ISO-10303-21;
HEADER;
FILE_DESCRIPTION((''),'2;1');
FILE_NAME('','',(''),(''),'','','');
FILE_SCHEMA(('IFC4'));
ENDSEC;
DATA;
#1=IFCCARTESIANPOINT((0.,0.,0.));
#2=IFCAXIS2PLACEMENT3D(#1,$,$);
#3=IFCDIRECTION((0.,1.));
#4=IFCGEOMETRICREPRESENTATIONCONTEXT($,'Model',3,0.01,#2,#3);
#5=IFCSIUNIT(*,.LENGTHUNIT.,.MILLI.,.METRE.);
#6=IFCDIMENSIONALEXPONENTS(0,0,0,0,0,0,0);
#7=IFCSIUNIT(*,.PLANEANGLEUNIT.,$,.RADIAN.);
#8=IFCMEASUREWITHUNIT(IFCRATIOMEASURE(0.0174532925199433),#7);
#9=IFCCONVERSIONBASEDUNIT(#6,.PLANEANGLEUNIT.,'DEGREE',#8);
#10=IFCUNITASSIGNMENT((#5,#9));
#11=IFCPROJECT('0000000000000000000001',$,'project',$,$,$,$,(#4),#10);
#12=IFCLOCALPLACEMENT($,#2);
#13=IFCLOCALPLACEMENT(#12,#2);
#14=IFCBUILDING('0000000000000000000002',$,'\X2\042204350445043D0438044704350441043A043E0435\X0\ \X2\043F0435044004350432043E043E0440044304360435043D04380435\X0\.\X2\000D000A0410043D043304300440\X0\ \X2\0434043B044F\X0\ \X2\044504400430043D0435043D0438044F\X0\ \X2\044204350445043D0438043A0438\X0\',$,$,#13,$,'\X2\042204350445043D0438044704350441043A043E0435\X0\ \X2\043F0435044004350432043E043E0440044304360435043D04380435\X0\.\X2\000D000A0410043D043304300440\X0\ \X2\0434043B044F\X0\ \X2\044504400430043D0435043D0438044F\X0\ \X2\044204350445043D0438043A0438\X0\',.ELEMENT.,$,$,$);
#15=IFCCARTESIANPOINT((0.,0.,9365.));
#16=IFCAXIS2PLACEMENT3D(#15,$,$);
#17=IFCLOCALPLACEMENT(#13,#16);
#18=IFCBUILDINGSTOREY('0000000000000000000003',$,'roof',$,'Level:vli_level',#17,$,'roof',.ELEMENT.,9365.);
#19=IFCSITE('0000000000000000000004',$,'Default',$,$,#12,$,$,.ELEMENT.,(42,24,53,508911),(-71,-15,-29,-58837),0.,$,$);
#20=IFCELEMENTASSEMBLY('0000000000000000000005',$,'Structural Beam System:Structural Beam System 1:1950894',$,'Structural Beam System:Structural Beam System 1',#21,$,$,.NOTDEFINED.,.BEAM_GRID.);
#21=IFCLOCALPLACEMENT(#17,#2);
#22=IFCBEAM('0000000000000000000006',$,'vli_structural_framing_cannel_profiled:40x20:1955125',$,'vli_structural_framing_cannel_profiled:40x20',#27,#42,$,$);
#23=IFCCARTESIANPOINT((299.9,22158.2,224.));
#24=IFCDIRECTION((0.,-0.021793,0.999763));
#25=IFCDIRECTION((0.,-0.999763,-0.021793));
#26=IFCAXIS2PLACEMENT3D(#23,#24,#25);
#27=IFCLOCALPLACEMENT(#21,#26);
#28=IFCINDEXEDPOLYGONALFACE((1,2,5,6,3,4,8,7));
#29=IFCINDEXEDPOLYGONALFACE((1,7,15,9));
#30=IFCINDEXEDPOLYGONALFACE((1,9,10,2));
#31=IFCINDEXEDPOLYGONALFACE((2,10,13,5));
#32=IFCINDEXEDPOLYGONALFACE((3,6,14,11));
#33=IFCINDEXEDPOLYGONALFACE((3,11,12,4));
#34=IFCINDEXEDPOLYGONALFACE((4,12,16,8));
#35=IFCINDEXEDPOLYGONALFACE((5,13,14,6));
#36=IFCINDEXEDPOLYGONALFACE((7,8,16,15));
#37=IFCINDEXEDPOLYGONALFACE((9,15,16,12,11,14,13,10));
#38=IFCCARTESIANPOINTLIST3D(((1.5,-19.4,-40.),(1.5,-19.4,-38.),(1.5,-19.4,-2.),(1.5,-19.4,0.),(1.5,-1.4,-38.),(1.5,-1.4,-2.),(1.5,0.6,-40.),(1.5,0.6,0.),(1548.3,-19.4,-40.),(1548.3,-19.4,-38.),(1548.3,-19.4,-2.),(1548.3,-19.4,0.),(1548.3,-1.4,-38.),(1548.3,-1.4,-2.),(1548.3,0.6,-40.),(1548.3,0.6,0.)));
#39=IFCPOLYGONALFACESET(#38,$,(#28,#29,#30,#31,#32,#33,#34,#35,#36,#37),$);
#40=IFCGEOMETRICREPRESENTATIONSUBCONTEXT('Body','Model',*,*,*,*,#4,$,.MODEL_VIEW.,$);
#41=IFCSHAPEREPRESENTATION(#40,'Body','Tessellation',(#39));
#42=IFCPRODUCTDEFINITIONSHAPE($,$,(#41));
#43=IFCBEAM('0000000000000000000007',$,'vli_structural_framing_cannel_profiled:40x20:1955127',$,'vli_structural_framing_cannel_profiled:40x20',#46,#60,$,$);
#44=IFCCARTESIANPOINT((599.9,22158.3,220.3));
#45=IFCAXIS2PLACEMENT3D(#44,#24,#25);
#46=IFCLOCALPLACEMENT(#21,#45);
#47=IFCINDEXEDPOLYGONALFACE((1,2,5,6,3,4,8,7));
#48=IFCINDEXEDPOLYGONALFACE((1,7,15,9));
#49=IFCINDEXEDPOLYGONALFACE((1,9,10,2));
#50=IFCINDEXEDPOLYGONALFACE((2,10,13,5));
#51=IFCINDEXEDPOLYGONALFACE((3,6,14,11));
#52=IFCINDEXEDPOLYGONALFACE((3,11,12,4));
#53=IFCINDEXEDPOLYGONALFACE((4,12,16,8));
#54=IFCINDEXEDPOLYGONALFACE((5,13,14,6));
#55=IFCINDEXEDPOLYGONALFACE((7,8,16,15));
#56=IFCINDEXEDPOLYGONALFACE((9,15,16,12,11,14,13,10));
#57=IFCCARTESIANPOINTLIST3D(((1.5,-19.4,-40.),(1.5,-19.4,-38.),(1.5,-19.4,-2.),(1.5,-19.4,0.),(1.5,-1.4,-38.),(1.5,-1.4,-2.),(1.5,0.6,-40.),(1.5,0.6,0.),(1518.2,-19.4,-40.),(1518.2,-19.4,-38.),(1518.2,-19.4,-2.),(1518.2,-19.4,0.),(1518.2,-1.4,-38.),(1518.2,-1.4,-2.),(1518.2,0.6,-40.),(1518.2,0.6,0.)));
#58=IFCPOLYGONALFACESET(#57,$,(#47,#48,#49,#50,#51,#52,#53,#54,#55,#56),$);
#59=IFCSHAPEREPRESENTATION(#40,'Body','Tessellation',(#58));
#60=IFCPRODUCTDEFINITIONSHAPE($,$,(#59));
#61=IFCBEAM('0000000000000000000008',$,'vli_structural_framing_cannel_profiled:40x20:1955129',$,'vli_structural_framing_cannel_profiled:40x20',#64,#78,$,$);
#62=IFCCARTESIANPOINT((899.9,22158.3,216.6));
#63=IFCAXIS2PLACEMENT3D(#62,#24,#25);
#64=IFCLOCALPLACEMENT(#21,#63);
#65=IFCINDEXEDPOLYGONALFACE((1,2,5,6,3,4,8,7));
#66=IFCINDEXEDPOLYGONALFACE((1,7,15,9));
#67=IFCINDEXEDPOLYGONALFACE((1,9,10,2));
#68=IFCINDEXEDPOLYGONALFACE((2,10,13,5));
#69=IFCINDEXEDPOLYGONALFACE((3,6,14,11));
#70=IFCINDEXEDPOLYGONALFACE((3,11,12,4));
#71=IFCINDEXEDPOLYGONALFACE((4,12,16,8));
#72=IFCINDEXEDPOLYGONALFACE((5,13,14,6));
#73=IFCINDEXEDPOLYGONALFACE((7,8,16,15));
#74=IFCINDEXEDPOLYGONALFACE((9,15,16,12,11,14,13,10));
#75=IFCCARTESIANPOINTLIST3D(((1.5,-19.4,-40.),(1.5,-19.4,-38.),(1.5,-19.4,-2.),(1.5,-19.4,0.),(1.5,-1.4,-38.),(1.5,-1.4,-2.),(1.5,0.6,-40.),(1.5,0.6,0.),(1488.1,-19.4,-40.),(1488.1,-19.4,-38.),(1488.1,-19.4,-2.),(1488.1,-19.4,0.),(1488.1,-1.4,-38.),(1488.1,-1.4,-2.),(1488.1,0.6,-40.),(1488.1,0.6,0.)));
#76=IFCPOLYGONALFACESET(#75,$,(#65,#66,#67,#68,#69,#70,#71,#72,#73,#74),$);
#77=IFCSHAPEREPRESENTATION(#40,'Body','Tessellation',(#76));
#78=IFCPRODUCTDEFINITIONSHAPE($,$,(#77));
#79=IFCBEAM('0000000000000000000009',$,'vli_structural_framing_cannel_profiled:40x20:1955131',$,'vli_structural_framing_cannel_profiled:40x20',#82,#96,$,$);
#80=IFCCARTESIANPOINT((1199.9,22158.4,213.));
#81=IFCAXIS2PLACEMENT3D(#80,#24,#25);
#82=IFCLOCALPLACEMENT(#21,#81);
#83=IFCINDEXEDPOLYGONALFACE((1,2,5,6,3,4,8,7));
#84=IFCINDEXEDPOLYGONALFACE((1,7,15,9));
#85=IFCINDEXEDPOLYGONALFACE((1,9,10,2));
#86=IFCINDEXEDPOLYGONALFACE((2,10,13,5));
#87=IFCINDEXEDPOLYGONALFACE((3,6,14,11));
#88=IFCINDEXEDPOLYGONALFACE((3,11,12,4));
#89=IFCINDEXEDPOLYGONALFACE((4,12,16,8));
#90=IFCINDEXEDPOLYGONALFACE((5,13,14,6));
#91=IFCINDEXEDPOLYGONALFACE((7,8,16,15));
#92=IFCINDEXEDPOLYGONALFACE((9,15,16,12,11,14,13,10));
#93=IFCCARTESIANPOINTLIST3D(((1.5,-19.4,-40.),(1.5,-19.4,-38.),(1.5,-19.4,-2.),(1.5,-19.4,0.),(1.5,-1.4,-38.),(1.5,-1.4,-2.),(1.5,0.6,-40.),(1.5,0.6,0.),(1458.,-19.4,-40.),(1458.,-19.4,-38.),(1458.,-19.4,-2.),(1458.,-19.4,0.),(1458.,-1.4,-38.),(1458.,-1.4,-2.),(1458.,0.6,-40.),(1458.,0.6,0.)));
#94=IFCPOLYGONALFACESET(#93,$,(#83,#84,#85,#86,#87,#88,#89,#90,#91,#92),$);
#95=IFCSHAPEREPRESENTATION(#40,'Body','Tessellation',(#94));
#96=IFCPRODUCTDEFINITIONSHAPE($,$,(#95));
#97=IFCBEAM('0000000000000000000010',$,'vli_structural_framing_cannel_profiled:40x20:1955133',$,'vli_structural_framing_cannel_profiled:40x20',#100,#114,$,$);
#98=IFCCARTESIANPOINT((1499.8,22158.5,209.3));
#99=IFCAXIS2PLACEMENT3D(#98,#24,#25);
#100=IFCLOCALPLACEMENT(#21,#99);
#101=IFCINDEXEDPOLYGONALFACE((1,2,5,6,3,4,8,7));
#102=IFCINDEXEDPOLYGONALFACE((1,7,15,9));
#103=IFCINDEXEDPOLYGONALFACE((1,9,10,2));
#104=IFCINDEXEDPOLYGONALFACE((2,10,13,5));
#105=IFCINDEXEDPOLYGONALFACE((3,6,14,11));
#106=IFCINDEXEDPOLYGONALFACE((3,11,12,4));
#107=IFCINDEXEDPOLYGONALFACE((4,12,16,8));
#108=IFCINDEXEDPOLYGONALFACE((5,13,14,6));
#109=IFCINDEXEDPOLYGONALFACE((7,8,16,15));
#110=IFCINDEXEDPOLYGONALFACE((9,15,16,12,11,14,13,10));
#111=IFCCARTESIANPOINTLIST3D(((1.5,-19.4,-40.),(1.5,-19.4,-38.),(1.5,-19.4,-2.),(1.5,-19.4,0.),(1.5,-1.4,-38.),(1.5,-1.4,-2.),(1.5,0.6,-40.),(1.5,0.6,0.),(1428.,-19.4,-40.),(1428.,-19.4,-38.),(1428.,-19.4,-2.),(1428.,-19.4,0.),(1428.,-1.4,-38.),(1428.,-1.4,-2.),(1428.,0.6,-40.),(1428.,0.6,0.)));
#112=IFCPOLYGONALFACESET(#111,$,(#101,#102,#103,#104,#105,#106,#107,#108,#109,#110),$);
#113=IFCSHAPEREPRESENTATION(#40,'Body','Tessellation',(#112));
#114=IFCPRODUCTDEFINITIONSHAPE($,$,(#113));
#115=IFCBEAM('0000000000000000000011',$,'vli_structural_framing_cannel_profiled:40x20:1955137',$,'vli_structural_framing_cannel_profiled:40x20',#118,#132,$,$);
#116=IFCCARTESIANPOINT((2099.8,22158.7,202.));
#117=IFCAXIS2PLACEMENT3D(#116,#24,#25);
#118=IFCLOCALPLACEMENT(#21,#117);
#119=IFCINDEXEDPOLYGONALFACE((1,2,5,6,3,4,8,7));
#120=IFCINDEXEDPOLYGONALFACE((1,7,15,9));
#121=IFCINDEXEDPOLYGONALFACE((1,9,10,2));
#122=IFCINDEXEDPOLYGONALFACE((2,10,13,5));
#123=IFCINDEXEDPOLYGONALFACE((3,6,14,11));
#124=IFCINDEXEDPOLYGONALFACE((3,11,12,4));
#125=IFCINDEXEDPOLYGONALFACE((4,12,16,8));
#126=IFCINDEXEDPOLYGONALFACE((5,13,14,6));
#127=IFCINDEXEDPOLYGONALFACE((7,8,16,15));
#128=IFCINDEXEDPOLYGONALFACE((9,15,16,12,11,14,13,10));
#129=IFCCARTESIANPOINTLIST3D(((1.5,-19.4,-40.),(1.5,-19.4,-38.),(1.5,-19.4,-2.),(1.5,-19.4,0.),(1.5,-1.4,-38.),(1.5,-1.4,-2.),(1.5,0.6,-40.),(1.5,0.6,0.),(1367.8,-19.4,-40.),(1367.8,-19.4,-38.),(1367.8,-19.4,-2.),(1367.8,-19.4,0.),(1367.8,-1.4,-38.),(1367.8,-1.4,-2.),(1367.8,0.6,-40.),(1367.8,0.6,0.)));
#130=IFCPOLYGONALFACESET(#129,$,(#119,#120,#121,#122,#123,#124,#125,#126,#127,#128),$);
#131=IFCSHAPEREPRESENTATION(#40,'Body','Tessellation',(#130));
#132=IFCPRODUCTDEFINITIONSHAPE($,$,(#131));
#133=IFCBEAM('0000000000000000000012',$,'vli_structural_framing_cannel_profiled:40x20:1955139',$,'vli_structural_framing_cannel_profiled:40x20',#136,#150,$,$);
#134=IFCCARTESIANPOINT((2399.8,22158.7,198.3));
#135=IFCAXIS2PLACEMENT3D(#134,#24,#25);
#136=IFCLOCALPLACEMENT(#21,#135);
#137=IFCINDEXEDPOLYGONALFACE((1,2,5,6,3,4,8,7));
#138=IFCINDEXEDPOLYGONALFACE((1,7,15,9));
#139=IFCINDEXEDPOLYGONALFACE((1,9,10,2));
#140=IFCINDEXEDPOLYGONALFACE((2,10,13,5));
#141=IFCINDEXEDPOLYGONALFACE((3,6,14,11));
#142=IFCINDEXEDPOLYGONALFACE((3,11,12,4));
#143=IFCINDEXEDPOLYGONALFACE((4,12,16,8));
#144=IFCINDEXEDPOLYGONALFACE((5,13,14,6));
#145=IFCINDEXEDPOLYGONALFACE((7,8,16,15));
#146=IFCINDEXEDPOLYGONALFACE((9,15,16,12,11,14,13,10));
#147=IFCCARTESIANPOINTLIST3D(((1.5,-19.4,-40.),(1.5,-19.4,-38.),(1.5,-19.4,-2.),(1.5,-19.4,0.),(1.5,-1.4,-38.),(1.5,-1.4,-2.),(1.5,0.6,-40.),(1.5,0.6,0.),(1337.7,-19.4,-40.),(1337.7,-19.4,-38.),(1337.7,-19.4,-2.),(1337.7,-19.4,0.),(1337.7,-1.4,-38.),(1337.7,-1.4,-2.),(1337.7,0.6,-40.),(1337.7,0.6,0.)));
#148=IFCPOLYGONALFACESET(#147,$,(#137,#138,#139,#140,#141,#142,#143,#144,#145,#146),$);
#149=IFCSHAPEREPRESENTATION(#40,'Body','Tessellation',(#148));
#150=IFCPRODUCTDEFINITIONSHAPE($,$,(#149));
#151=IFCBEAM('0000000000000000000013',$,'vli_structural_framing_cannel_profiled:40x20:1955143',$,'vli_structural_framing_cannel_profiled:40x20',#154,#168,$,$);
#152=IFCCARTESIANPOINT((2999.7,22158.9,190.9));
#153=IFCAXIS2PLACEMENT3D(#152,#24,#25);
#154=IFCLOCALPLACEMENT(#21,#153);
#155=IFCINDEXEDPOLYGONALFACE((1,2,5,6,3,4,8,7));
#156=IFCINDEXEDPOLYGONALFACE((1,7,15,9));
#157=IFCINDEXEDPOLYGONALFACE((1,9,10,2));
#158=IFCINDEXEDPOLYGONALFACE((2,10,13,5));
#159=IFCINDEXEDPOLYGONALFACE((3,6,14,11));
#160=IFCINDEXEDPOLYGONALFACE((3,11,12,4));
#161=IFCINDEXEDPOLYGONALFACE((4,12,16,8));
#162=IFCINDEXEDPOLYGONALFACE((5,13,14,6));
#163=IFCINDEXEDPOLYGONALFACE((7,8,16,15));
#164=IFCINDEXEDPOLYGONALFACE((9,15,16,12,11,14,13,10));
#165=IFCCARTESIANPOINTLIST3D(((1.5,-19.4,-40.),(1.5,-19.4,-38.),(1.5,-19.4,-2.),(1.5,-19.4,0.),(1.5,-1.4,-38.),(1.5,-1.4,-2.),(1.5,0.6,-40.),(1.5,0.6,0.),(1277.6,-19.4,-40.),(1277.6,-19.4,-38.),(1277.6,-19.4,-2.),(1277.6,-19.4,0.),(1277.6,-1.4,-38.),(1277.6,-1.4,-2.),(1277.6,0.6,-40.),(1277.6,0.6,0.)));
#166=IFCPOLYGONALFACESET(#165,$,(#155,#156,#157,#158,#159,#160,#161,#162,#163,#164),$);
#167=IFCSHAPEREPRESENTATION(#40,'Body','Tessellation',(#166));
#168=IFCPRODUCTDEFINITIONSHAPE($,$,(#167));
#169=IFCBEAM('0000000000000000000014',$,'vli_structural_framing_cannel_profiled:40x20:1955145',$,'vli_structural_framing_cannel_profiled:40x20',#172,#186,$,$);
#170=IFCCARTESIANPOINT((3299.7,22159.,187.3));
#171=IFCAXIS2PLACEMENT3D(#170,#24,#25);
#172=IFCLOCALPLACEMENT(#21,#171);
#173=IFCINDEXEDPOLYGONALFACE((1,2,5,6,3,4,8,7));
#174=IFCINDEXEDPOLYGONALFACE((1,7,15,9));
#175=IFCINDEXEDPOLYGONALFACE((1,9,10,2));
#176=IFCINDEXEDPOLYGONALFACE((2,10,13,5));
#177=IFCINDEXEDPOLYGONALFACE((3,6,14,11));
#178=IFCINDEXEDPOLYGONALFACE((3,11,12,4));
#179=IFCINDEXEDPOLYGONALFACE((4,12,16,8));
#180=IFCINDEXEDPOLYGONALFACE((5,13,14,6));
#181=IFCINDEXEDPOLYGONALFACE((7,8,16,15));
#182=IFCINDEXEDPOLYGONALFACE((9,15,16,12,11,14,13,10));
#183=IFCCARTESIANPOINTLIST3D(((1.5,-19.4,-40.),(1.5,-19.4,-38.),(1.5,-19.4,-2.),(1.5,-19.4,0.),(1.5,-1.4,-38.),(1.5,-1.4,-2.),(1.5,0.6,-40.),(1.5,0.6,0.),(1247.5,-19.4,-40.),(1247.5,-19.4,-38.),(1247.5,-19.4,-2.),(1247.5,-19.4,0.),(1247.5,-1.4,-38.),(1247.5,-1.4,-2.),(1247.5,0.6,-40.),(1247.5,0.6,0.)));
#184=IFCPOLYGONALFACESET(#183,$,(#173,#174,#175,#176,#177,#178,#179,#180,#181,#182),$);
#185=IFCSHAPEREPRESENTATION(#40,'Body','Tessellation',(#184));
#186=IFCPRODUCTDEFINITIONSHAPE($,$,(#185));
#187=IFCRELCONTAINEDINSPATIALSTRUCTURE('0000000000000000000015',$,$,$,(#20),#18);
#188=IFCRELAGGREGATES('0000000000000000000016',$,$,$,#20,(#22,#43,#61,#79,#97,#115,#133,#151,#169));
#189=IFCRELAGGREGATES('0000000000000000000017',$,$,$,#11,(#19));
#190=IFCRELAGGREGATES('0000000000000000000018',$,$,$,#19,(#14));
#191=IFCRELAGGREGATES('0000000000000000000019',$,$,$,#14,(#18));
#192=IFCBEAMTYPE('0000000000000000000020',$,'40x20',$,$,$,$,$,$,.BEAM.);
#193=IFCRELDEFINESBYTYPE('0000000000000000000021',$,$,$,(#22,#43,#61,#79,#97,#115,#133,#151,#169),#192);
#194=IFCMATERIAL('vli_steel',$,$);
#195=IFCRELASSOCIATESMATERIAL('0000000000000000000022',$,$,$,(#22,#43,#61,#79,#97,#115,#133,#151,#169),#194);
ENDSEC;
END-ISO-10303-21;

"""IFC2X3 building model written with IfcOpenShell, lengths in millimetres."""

from ifc_helpers import new_model, entity, si_unit, converted_unit, direction, frame, origin, place, context, subcontext, project, spatial, polyline, outline, extrude, material, type_object, element, aggregate, save


model = new_model("IFC2X3")

# Units and contexts
model_context = context("Model", 3, precision=0.01, world=origin(), true_north=direction((0.0, 1.0)))
body_context = subcontext(model_context, "Body", "Model", "MODEL_VIEW")
ifc_project = project(units=[si_unit("LENGTHUNIT", "METRE", prefix="MILLI"), converted_unit("PLANEANGLEUNIT", "DEGREE", entity("IfcRatioMeasure", 0.0174532925199433), si_unit("PLANEANGLEUNIT", "RADIAN"), dimensions=[0, 0, 0, 0, 0, 0, 0])], contexts=[model_context])

# Site, building, storey
site_placement = place(None, origin())
site = spatial("IfcSite", under=ifc_project, at=site_placement, Name="Default", CompositionType="ELEMENT", RefLatitude=(42, 24, 53, 508911), RefLongitude=(-71, -15, -29, -58837), RefElevation=0.0)
building_placement = place(site_placement, origin())
building = spatial("IfcBuilding", under=site, at=building_placement, Name="Техническое перевооружение.\r\nАнгар для хранения техники", LongName="Техническое перевооружение.\r\nАнгар для хранения техники", CompositionType="ELEMENT")
storey_placement = place(building_placement, frame((0.0, 0.0, 9365.0)))
storey = spatial("IfcBuildingStorey", under=building, at=storey_placement, Name="roof", ObjectType="Level:vli_level", LongName="roof", CompositionType="ELEMENT", Elevation=9365.0)

# Element assembly, beams
ifc_material = material(Name="vli_steel")
beam_type = type_object("IfcBeamType", Name="40x20", PredefinedType="BEAM")
assembly_1_placement = place(storey_placement, origin())
assembly_1 = element("IfcElementAssembly", 1, at=assembly_1_placement, inside=storey, Name="Structural Beam System:Structural Beam System 1:1950894", ObjectType="Structural Beam System:Structural Beam System 1", AssemblyPlace="NOTDEFINED", PredefinedType="BEAM_GRID")
beam_1_placement = place(assembly_1_placement, frame((299.9, 22158.2, 224.0), z_axis=(0.0, -0.021793, 0.999763), x_axis=(0.0, -0.999763, -0.021793)))
beam_1 = element("IfcBeam", 2, at=beam_1_placement, type_object=beam_type, material=ifc_material, Name="vli_structural_framing_cannel_profiled:40x20:1955125", ObjectType="vli_structural_framing_cannel_profiled:40x20", context=body_context, shape_type="SweptSolid", body=[
    extrude(outline(polyline([(-20.0, -9.5), (-18.0, -9.5), (-18.0, 8.5), (18.0, 8.5), (18.0, -9.5), (20.0, -9.5), (20.0, 10.5), (-20.0, 10.5), (-20.0, -9.5)])), frame((1.5, -9.9, -20.0), z_axis=(1.0, 0.0, 0.0), x_axis=(0.0, 0.0, -1.0)), (0.0, 0.0, 1.0), 1546.8),
])
beam_2_placement = place(assembly_1_placement, frame((599.9, 22158.3, 220.3), z_axis=(0.0, -0.021793, 0.999763), x_axis=(0.0, -0.999763, -0.021793)))
beam_2 = element("IfcBeam", 3, at=beam_2_placement, type_object=beam_type, material=ifc_material, Name="vli_structural_framing_cannel_profiled:40x20:1955127", ObjectType="vli_structural_framing_cannel_profiled:40x20", context=body_context, shape_type="SweptSolid", body=[
    extrude(outline(polyline([(-20.0, -9.5), (-18.0, -9.5), (-18.0, 8.5), (18.0, 8.5), (18.0, -9.5), (20.0, -9.5), (20.0, 10.5), (-20.0, 10.5), (-20.0, -9.5)])), frame((1.5, -9.9, -20.0), z_axis=(1.0, 0.0, 0.0), x_axis=(0.0, 0.0, -1.0)), (0.0, 0.0, 1.0), 1516.7),
])
beam_3_placement = place(assembly_1_placement, frame((899.9, 22158.3, 216.6), z_axis=(0.0, -0.021793, 0.999763), x_axis=(0.0, -0.999763, -0.021793)))
beam_3 = element("IfcBeam", 4, at=beam_3_placement, type_object=beam_type, material=ifc_material, Name="vli_structural_framing_cannel_profiled:40x20:1955129", ObjectType="vli_structural_framing_cannel_profiled:40x20", context=body_context, shape_type="SweptSolid", body=[
    extrude(outline(polyline([(-20.0, -9.5), (-18.0, -9.5), (-18.0, 8.5), (18.0, 8.5), (18.0, -9.5), (20.0, -9.5), (20.0, 10.5), (-20.0, 10.5), (-20.0, -9.5)])), frame((1.5, -9.9, -20.0), z_axis=(1.0, 0.0, 0.0), x_axis=(0.0, 0.0, -1.0)), (0.0, 0.0, 1.0), 1486.6),
])
beam_4_placement = place(assembly_1_placement, frame((1199.9, 22158.4, 213.0), z_axis=(0.0, -0.021793, 0.999763), x_axis=(0.0, -0.999763, -0.021793)))
beam_4 = element("IfcBeam", 5, at=beam_4_placement, type_object=beam_type, material=ifc_material, Name="vli_structural_framing_cannel_profiled:40x20:1955131", ObjectType="vli_structural_framing_cannel_profiled:40x20", context=body_context, shape_type="SweptSolid", body=[
    extrude(outline(polyline([(-20.0, -9.5), (-18.0, -9.5), (-18.0, 8.5), (18.0, 8.5), (18.0, -9.5), (20.0, -9.5), (20.0, 10.5), (-20.0, 10.5), (-20.0, -9.5)])), frame((1.5, -9.9, -20.0), z_axis=(1.0, 0.0, 0.0), x_axis=(0.0, 0.0, -1.0)), (0.0, 0.0, 1.0), 1456.6),
])
beam_5_placement = place(assembly_1_placement, frame((1499.8, 22158.5, 209.3), z_axis=(0.0, -0.021793, 0.999763), x_axis=(0.0, -0.999763, -0.021793)))
beam_5 = element("IfcBeam", 6, at=beam_5_placement, type_object=beam_type, material=ifc_material, Name="vli_structural_framing_cannel_profiled:40x20:1955133", ObjectType="vli_structural_framing_cannel_profiled:40x20", context=body_context, shape_type="SweptSolid", body=[
    extrude(outline(polyline([(-20.0, -9.5), (-18.0, -9.5), (-18.0, 8.5), (18.0, 8.5), (18.0, -9.5), (20.0, -9.5), (20.0, 10.5), (-20.0, 10.5), (-20.0, -9.5)])), frame((1.5, -9.9, -20.0), z_axis=(1.0, 0.0, 0.0), x_axis=(0.0, 0.0, -1.0)), (0.0, 0.0, 1.0), 1426.5),
])
beam_6_placement = place(assembly_1_placement, frame((2099.8, 22158.7, 202.0), z_axis=(0.0, -0.021793, 0.999763), x_axis=(0.0, -0.999763, -0.021793)))
beam_6 = element("IfcBeam", 7, at=beam_6_placement, type_object=beam_type, material=ifc_material, Name="vli_structural_framing_cannel_profiled:40x20:1955137", ObjectType="vli_structural_framing_cannel_profiled:40x20", context=body_context, shape_type="SweptSolid", body=[
    extrude(outline(polyline([(-20.0, -9.5), (-18.0, -9.5), (-18.0, 8.5), (18.0, 8.5), (18.0, -9.5), (20.0, -9.5), (20.0, 10.5), (-20.0, 10.5), (-20.0, -9.5)])), frame((1.5, -9.9, -20.0), z_axis=(1.0, 0.0, 0.0), x_axis=(0.0, 0.0, -1.0)), (0.0, 0.0, 1.0), 1366.3),
])
beam_7_placement = place(assembly_1_placement, frame((2399.8, 22158.7, 198.3), z_axis=(0.0, -0.021793, 0.999763), x_axis=(0.0, -0.999763, -0.021793)))
beam_7 = element("IfcBeam", 8, at=beam_7_placement, type_object=beam_type, material=ifc_material, Name="vli_structural_framing_cannel_profiled:40x20:1955139", ObjectType="vli_structural_framing_cannel_profiled:40x20", context=body_context, shape_type="SweptSolid", body=[
    extrude(outline(polyline([(-20.0, -9.5), (-18.0, -9.5), (-18.0, 8.5), (18.0, 8.5), (18.0, -9.5), (20.0, -9.5), (20.0, 10.5), (-20.0, 10.5), (-20.0, -9.5)])), frame((1.5, -9.9, -20.0), z_axis=(1.0, 0.0, 0.0), x_axis=(0.0, 0.0, -1.0)), (0.0, 0.0, 1.0), 1336.3),
])
beam_8_placement = place(assembly_1_placement, frame((2999.7, 22158.9, 190.9), z_axis=(0.0, -0.021793, 0.999763), x_axis=(0.0, -0.999763, -0.021793)))
beam_8 = element("IfcBeam", 9, at=beam_8_placement, type_object=beam_type, material=ifc_material, Name="vli_structural_framing_cannel_profiled:40x20:1955143", ObjectType="vli_structural_framing_cannel_profiled:40x20", context=body_context, shape_type="SweptSolid", body=[
    extrude(outline(polyline([(-20.0, -9.5), (-18.0, -9.5), (-18.0, 8.5), (18.0, 8.5), (18.0, -9.5), (20.0, -9.5), (20.0, 10.5), (-20.0, 10.5), (-20.0, -9.5)])), frame((1.5, -9.9, -20.0), z_axis=(1.0, 0.0, 0.0), x_axis=(0.0, 0.0, -1.0)), (0.0, 0.0, 1.0), 1276.1),
])
beam_9_placement = place(assembly_1_placement, frame((3299.7, 22159.0, 187.3), z_axis=(0.0, -0.021793, 0.999763), x_axis=(0.0, -0.999763, -0.021793)))
beam_9 = element("IfcBeam", 10, at=beam_9_placement, type_object=beam_type, material=ifc_material, Name="vli_structural_framing_cannel_profiled:40x20:1955145", ObjectType="vli_structural_framing_cannel_profiled:40x20", context=body_context, shape_type="SweptSolid", body=[
    extrude(outline(polyline([(-20.0, -9.5), (-18.0, -9.5), (-18.0, 8.5), (18.0, 8.5), (18.0, -9.5), (20.0, -9.5), (20.0, 10.5), (-20.0, 10.5), (-20.0, -9.5)])), frame((1.5, -9.9, -20.0), z_axis=(1.0, 0.0, 0.0), x_axis=(0.0, 0.0, -1.0)), (0.0, 0.0, 1.0), 1246.0),
])
aggregate(assembly_1, [beam_1, beam_2, beam_3, beam_4, beam_5, beam_6, beam_7, beam_8, beam_9])

save(model, "model.ifc")
